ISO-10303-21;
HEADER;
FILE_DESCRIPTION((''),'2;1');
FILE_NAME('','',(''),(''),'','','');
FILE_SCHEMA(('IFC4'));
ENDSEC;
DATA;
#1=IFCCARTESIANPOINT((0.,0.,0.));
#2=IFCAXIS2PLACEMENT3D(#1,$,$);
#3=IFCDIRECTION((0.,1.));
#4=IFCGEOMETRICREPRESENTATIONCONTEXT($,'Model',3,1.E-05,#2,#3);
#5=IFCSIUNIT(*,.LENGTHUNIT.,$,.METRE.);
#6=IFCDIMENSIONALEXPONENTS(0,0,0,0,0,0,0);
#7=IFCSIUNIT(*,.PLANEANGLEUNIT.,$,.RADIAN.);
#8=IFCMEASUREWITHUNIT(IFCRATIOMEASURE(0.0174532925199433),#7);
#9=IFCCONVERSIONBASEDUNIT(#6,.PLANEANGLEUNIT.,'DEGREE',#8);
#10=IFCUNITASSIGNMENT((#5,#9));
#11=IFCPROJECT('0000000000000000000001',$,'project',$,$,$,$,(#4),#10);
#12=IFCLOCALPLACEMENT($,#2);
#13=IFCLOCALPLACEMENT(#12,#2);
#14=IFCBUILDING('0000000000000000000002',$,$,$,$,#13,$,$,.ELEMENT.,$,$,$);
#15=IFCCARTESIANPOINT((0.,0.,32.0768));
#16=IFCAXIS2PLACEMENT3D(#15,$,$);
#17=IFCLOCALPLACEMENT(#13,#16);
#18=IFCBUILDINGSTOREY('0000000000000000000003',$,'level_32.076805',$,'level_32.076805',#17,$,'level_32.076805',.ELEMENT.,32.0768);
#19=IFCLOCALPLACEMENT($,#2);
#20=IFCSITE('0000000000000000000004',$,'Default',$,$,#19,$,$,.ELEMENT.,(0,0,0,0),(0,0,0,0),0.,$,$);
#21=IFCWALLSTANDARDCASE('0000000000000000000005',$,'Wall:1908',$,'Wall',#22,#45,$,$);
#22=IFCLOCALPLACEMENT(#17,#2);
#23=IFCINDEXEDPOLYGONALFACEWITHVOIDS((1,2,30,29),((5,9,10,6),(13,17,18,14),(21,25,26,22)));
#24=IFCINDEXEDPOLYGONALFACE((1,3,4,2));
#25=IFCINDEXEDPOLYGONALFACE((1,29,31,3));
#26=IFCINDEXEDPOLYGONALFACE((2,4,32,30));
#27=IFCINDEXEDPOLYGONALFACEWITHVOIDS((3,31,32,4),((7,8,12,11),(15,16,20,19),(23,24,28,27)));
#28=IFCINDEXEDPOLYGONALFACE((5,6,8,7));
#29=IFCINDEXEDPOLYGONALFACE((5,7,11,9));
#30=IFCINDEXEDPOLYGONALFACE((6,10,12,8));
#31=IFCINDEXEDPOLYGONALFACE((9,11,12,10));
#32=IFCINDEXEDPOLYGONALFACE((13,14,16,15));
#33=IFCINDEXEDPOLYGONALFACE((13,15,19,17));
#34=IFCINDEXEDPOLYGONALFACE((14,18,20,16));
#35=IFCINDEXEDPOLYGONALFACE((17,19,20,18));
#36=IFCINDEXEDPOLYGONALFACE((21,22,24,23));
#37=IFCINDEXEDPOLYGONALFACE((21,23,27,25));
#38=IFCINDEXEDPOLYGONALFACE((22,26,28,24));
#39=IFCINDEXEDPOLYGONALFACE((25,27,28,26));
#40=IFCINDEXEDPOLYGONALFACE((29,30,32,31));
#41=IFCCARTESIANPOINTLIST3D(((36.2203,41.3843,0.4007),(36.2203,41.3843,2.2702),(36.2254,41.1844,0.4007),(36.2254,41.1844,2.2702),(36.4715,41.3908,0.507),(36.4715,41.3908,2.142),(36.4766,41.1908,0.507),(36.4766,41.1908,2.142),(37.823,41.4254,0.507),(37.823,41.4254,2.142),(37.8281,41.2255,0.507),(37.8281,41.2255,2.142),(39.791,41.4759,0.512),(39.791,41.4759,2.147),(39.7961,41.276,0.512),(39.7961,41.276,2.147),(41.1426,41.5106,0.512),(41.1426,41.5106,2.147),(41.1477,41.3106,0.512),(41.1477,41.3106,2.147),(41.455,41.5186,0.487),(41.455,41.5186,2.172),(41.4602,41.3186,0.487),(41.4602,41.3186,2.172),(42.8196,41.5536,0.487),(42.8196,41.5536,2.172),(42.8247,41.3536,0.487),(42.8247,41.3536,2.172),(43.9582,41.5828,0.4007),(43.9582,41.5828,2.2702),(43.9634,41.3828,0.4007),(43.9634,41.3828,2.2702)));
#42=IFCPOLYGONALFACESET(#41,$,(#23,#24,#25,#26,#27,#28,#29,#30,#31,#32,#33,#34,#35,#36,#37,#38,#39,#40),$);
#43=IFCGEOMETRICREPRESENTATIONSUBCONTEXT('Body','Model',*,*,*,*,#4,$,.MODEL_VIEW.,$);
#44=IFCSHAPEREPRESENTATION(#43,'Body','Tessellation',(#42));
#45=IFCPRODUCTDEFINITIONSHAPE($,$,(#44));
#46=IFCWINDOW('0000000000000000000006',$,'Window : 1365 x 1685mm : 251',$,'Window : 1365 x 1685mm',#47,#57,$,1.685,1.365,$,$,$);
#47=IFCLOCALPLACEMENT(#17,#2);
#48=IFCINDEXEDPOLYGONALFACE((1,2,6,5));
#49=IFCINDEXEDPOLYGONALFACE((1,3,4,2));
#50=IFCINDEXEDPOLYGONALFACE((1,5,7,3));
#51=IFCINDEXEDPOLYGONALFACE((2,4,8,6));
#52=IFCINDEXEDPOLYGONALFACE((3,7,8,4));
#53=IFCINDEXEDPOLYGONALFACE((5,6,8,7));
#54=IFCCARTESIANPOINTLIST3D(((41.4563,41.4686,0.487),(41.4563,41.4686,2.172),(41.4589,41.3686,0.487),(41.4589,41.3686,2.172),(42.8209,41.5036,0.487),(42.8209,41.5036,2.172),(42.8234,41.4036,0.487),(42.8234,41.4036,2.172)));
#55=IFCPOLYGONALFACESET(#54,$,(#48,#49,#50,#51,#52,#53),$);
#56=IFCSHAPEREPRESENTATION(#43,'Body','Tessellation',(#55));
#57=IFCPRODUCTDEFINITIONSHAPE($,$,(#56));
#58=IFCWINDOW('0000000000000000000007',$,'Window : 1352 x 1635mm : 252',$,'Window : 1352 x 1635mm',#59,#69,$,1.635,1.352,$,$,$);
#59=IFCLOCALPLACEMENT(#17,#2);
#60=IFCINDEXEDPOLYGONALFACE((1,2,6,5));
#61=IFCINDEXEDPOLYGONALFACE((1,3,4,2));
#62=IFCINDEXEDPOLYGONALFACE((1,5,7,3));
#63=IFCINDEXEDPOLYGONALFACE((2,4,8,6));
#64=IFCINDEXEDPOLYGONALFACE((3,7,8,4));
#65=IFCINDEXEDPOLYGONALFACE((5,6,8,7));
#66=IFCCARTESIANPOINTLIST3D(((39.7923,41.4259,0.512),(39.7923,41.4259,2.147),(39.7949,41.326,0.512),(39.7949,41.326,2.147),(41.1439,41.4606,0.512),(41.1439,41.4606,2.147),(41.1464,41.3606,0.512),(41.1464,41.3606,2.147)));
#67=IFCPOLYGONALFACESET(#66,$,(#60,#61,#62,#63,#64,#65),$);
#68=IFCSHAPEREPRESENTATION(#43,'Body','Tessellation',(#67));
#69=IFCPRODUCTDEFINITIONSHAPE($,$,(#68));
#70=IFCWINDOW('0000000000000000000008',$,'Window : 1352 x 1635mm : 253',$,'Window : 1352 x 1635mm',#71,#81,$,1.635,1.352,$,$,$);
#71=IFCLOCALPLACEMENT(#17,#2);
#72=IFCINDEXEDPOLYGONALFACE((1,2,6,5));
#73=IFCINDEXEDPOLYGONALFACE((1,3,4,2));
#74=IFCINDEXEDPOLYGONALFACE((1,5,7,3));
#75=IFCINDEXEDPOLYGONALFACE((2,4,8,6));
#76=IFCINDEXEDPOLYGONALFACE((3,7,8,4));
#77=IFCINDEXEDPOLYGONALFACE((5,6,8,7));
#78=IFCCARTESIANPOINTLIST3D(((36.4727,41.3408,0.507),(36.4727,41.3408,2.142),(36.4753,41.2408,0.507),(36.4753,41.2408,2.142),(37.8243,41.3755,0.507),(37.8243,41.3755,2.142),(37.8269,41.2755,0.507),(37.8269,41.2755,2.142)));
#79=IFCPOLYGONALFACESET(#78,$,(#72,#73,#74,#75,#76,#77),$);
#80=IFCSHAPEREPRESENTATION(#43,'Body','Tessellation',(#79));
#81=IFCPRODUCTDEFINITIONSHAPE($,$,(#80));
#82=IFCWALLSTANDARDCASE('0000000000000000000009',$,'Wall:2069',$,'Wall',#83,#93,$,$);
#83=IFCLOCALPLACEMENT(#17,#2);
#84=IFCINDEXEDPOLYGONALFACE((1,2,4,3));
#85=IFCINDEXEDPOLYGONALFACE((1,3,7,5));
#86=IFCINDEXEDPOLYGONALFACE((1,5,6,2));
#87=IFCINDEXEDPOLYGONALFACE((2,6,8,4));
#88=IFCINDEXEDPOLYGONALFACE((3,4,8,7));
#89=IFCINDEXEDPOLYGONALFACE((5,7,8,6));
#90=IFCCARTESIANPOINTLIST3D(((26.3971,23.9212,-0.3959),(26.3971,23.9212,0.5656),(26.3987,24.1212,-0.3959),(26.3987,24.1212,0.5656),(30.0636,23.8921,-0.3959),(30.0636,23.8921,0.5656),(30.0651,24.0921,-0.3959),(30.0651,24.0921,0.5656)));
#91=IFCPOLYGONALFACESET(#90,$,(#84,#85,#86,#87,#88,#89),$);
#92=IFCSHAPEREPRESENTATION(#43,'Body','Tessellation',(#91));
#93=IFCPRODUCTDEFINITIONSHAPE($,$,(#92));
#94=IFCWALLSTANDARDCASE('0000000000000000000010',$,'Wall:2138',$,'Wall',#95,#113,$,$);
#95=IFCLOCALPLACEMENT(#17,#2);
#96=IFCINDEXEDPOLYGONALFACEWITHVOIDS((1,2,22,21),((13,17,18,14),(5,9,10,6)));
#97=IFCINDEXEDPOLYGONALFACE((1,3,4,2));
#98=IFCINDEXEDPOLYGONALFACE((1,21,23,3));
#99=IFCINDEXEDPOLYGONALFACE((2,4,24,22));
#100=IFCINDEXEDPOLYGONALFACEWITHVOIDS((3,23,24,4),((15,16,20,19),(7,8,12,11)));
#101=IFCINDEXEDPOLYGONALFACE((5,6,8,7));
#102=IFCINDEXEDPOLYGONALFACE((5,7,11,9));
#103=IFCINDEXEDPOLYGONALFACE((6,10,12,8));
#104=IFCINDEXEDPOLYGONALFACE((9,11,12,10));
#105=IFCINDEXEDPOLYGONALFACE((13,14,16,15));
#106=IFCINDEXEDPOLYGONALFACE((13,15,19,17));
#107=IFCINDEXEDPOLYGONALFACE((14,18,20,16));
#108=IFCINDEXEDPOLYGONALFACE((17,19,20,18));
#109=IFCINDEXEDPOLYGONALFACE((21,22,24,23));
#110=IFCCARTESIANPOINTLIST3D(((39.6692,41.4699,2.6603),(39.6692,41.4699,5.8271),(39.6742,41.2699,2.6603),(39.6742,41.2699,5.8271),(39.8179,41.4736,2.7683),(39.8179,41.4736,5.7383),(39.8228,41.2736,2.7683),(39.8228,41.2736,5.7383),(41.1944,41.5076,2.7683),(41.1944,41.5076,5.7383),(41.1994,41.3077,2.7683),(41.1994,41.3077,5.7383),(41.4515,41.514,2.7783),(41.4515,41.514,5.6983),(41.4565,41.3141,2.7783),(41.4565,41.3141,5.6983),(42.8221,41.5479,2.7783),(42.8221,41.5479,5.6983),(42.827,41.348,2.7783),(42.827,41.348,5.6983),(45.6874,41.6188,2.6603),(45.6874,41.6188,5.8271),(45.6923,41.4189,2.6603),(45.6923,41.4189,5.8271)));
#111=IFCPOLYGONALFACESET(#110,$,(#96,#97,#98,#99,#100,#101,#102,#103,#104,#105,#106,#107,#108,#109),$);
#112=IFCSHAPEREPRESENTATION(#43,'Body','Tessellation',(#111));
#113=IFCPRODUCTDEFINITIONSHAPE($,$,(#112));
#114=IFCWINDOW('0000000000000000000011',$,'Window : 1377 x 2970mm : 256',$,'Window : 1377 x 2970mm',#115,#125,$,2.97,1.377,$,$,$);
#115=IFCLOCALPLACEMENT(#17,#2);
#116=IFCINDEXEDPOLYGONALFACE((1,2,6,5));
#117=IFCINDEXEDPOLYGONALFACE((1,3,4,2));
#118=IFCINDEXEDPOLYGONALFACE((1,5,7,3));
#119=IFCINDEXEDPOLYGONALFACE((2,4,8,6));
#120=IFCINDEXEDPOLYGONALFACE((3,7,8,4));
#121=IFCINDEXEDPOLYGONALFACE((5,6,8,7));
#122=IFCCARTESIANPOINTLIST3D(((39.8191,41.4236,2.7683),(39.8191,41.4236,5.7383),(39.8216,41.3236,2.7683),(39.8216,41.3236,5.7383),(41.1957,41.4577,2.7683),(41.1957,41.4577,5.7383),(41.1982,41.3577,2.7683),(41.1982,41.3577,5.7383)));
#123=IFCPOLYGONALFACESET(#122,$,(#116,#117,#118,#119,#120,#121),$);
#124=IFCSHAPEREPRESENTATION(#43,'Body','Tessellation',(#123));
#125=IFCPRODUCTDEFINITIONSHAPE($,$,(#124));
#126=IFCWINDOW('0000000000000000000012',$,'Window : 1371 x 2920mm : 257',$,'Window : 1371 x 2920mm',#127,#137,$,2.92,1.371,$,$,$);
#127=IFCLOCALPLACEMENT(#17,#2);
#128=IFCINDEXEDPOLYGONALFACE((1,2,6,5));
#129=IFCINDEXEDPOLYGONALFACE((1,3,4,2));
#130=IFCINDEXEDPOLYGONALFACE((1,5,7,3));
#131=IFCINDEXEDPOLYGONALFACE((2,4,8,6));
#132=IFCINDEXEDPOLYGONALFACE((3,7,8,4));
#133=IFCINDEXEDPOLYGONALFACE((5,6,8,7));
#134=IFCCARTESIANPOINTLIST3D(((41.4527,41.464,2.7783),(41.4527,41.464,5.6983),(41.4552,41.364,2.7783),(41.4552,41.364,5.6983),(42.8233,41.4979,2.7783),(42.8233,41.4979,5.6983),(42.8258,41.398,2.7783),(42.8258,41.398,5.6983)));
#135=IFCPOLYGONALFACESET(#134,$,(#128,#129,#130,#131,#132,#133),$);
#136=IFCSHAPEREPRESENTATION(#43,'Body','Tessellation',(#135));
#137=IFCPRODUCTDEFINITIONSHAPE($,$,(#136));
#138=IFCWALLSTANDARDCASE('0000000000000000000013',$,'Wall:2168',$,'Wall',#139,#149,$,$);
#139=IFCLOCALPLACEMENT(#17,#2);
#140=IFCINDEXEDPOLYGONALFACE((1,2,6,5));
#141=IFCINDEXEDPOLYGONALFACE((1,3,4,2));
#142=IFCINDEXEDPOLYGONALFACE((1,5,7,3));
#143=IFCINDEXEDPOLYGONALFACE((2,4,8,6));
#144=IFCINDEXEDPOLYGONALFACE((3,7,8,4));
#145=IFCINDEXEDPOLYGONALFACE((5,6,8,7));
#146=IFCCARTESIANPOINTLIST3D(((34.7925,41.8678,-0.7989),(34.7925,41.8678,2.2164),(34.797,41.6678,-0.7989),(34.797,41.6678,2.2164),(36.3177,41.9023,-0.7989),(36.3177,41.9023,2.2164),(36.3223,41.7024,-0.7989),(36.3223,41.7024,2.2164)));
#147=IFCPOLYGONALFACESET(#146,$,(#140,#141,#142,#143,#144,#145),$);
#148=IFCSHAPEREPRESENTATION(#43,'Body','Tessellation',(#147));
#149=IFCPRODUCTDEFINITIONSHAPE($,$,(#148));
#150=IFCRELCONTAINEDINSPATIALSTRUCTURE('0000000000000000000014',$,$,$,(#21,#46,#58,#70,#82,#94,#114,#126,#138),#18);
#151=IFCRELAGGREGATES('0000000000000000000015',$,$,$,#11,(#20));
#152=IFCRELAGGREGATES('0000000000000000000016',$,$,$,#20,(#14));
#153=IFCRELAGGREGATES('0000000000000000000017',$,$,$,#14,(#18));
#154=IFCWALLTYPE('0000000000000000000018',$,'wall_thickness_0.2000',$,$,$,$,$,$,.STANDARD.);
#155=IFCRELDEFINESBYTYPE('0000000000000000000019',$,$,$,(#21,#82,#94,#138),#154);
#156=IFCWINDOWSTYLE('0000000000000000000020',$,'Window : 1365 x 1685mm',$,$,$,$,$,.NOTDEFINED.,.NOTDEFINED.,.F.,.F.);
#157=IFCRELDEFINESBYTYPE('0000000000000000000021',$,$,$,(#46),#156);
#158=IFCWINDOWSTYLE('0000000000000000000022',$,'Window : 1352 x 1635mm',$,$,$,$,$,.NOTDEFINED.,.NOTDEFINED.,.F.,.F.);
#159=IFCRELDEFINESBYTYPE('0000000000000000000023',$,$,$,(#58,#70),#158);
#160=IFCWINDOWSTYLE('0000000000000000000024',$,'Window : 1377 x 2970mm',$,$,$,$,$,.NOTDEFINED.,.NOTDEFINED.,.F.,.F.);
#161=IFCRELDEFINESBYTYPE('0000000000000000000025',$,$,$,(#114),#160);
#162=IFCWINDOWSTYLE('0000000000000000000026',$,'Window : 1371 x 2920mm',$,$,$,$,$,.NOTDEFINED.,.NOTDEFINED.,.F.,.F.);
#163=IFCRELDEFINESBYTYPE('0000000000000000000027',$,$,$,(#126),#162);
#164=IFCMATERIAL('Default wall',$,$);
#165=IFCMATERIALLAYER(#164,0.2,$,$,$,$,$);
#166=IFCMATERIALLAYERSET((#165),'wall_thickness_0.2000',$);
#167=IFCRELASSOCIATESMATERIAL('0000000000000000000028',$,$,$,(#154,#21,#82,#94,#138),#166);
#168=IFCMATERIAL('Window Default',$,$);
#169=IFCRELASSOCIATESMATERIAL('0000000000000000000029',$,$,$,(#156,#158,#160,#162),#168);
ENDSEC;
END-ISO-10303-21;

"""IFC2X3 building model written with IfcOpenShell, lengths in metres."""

from ifc_helpers import new_model, entity, si_unit, converted_unit, direction, frame, frame_2d, origin, origin_2d_with_axis, place, context, subcontext, project, spatial, polyline, rectangle, outline, extrude, source, transform, mapped, material, layer, layer_set, layer_usage, type_object, type_shapes, element, fill, save


model = new_model("IFC2X3")

# Units and contexts
model_context = context("Model", 3, precision=1e-05, world=origin(), true_north=direction((0.0, 1.0)))
body_context = subcontext(model_context, "Body", "Model", "MODEL_VIEW")
ifc_project = project(units=[si_unit("LENGTHUNIT", "METRE"), converted_unit("PLANEANGLEUNIT", "DEGREE", entity("IfcRatioMeasure", 0.0174532925199433), si_unit("PLANEANGLEUNIT", "RADIAN"), dimensions=[0, 0, 0, 0, 0, 0, 0])], contexts=[model_context])

# Site, building, storey
site_placement = place(None, origin())
site = spatial("IfcSite", under=ifc_project, at=site_placement, Name="Default", CompositionType="ELEMENT", RefLatitude=(0, 0, 0, 0), RefLongitude=(0, 0, 0, 0), RefElevation=0.0)
placement_1 = place(None, origin())
building_placement = place(placement_1, origin())
building = spatial("IfcBuilding", under=site, at=building_placement, CompositionType="ELEMENT")
storey_placement = place(building_placement, frame((0.0, 0.0, 32.0768)))
storey = spatial("IfcBuildingStorey", under=building, at=storey_placement, Name="level_32.076805", ObjectType="level_32.076805", LongName="level_32.076805", CompositionType="ELEMENT", Elevation=32.0768)

# Shared definitions
ifc_material_1 = material(Name="Default wall")
ifc_layer = layer(ifc_material_1, 0.2)
ifc_layer_set = layer_set([ifc_layer], Name="wall_thickness_0.2000")
ifc_layer_usage = layer_usage(ifc_layer_set, "AXIS2", "POSITIVE", -0.1)
wall_type = type_object("IfcWallType", Name="wall_thickness_0.2000", PredefinedType="STANDARD", material=ifc_layer_set)

# Wall, openings, windows
placement_2 = place(building_placement, frame((0.0, 0.0, 32.4775)))
wall_1_placement = place(placement_2, frame((36.2228, 41.2844, 0.0), z_axis=(0.0, 0.0, 1.0), x_axis=(0.999671, 0.025636, 0.0)))
wall_1 = element("IfcWallStandardCase", 1, at=wall_1_placement, inside=storey, type_object=wall_type, material=ifc_layer_usage, Name="Wall:1908", ObjectType="Wall", context=body_context, shape_type="SweptSolid", body=[
    extrude(outline(polyline([(7.7405, -0.1), (7.7405, 0.1), (0.0, 0.1), (0.0, -0.1), (7.7405, -0.1)])), origin(), (0.0, 0.0, 1.0), 1.8695),
])
opening_1_placement = place(wall_1_placement, frame((5.2365, -0.1, 0.0863)))
opening_1 = element("IfcOpeningElement", 2, at=opening_1_placement, cuts=wall_1, ObjectType="Opening", context=body_context, shape_type="SweptSolid", body=[
    extrude(rectangle(XDim=1.365, YDim=1.685, at=frame_2d((0.8425, 0.6825), x_axis=(0.0, 1.0))), frame((0.0, 0.0, 0.0), z_axis=(0.0, 1.0, 0.0), x_axis=(0.0, 0.0, 1.0)), (0.0, 0.0, 1.0), 0.2),
])
opening_2_placement = place(wall_1_placement, frame((3.5719, -0.1, 0.1113)))
opening_2 = element("IfcOpeningElement", 3, at=opening_2_placement, cuts=wall_1, ObjectType="Opening", context=body_context, shape_type="SweptSolid", body=[
    extrude(rectangle(XDim=1.352, YDim=1.635, at=frame_2d((0.8175, 0.676), x_axis=(0.0, 1.0))), frame((0.0, 0.0, 0.0), z_axis=(0.0, 1.0, 0.0), x_axis=(0.0, 0.0, 1.0)), (0.0, 0.0, 1.0), 0.2),
])
opening_3_placement = place(wall_1_placement, frame((0.2513, -0.1, 0.1063)))
opening_3 = element("IfcOpeningElement", 4, at=opening_3_placement, cuts=wall_1, ObjectType="Opening", context=body_context, shape_type="SweptSolid", body=[
    extrude(rectangle(XDim=1.352, YDim=1.635, at=frame_2d((0.8175, 0.676), x_axis=(0.0, 1.0))), frame((0.0, 0.0, 0.0), z_axis=(0.0, 1.0, 0.0), x_axis=(0.0, 0.0, 1.0)), (0.0, 0.0, 1.0), 0.2),
])
ifc_material_2 = material(Name="Window Default")
window_style_1 = type_object("IfcWindowStyle", Name="Window : 1365 x 1685mm", ConstructionType="NOTDEFINED", OperationType="NOTDEFINED", ParameterTakesPrecedence=False, Sizeable=False, material=ifc_material_2)
shared_shape_1 = source(origin(), body_context, "Body", "SweptSolid", [
    extrude(rectangle(XDim=0.1, YDim=1.365, at=origin_2d_with_axis()), frame((0.6825, 0.1, 0.0), z_axis=(0.0, 0.0, 1.0), x_axis=(0.0, 1.0, 0.0)), (0.0, 0.0, 1.0), 1.685),
])
type_shapes(window_style_1, [shared_shape_1])
window_1_placement = place(opening_1_placement, origin())
window_1 = element("IfcWindow", 5, at=window_1_placement, inside=storey, type_object=window_style_1, Name="Window : 1365 x 1685mm : 251", ObjectType="Window : 1365 x 1685mm", OverallHeight=1.685, OverallWidth=1.365, context=body_context, shape_type="MappedRepresentation", body=[
    mapped(shared_shape_1, transform((0.0, 0.0, 0.0), scale=1.0)),
])
fill(opening_1, window_1)
window_style_2 = type_object("IfcWindowStyle", Name="Window : 1352 x 1635mm", ConstructionType="NOTDEFINED", OperationType="NOTDEFINED", ParameterTakesPrecedence=False, Sizeable=False, material=ifc_material_2)
shared_shape_2 = source(origin(), body_context, "Body", "SweptSolid", [
    extrude(rectangle(XDim=0.1, YDim=1.352, at=origin_2d_with_axis()), frame((0.676, 0.1, 0.0), z_axis=(0.0, 0.0, 1.0), x_axis=(0.0, 1.0, 0.0)), (0.0, 0.0, 1.0), 1.635),
])
type_shapes(window_style_2, [shared_shape_2])
window_2_placement = place(opening_2_placement, origin())
window_2 = element("IfcWindow", 6, at=window_2_placement, inside=storey, type_object=window_style_2, Name="Window : 1352 x 1635mm : 252", ObjectType="Window : 1352 x 1635mm", OverallHeight=1.635, OverallWidth=1.352, context=body_context, shape_type="MappedRepresentation", body=[
    mapped(shared_shape_2, transform((0.0, 0.0, 0.0), scale=1.0)),
])
fill(opening_2, window_2)
window_3_placement = place(opening_3_placement, origin())
window_3 = element("IfcWindow", 7, at=window_3_placement, inside=storey, type_object=window_style_2, Name="Window : 1352 x 1635mm : 253", ObjectType="Window : 1352 x 1635mm", OverallHeight=1.635, OverallWidth=1.352, context=body_context, shape_type="MappedRepresentation", body=[
    mapped(shared_shape_2, transform((0.0, 0.0, 0.0), scale=1.0)),
])
fill(opening_3, window_3)

# Wall
placement_3 = place(building_placement, frame((0.0, 0.0, 31.6809)))
wall_2_placement = place(placement_3, frame((26.3979, 24.0212, 0.0), z_axis=(0.0, 0.0, 1.0), x_axis=(0.999969, -0.007935, 0.0)))
element("IfcWallStandardCase", 8, at=wall_2_placement, inside=storey, type_object=wall_type, material=ifc_layer_usage, Name="Wall:2069", ObjectType="Wall", context=body_context, shape_type="SweptSolid", body=[
    extrude(outline(polyline([(3.6666, -0.1), (3.6666, 0.1), (0.0, 0.1), (0.0, -0.1), (3.6666, -0.1)])), origin(), (0.0, 0.0, 1.0), 0.9616),
])

# Wall, openings, windows
placement_4 = place(building_placement, frame((0.0, 0.0, 34.7371)))
wall_3_placement = place(placement_4, frame((39.6717, 41.3699, 0.0), z_axis=(0.0, 0.0, 1.0), x_axis=(0.999694, 0.024744, 0.0)))
wall_3 = element("IfcWallStandardCase", 9, at=wall_3_placement, inside=storey, type_object=wall_type, material=ifc_layer_usage, Name="Wall:2138", ObjectType="Wall", context=body_context, shape_type="SweptSolid", body=[
    extrude(outline(polyline([(6.02, -0.1), (6.02, 0.1), (0.0, 0.1), (0.0, -0.1), (6.02, -0.1)])), origin(), (0.0, 0.0, 1.0), 3.1668),
])
opening_4_placement = place(wall_3_placement, frame((0.1487, -0.1, 0.108)))
opening_4 = element("IfcOpeningElement", 10, at=opening_4_placement, cuts=wall_3, ObjectType="Opening", context=body_context, shape_type="SweptSolid", body=[
    extrude(rectangle(XDim=1.377, YDim=2.97, at=frame_2d((1.485, 0.6885), x_axis=(0.0, 1.0))), frame((0.0, 0.0, 0.0), z_axis=(0.0, 1.0, 0.0), x_axis=(0.0, 0.0, 1.0)), (0.0, 0.0, 1.0), 0.2),
])
opening_5_placement = place(wall_3_placement, frame((1.7828, -0.1, 0.118)))
opening_5 = element("IfcOpeningElement", 11, at=opening_5_placement, cuts=wall_3, ObjectType="Opening", context=body_context, shape_type="SweptSolid", body=[
    extrude(rectangle(XDim=1.371, YDim=2.92, at=frame_2d((1.46, 0.6855), x_axis=(0.0, 1.0))), frame((0.0, 0.0, 0.0), z_axis=(0.0, 1.0, 0.0), x_axis=(0.0, 0.0, 1.0)), (0.0, 0.0, 1.0), 0.2),
])
window_style_3 = type_object("IfcWindowStyle", Name="Window : 1377 x 2970mm", ConstructionType="NOTDEFINED", OperationType="NOTDEFINED", ParameterTakesPrecedence=False, Sizeable=False, material=ifc_material_2)
shared_shape_3 = source(origin(), body_context, "Body", "SweptSolid", [
    extrude(rectangle(XDim=0.1, YDim=1.377, at=origin_2d_with_axis()), frame((0.6885, 0.1, 0.0), z_axis=(0.0, 0.0, 1.0), x_axis=(0.0, 1.0, 0.0)), (0.0, 0.0, 1.0), 2.97),
])
type_shapes(window_style_3, [shared_shape_3])
window_4_placement = place(opening_4_placement, origin())
window_4 = element("IfcWindow", 12, at=window_4_placement, inside=storey, type_object=window_style_3, Name="Window : 1377 x 2970mm : 256", ObjectType="Window : 1377 x 2970mm", OverallHeight=2.97, OverallWidth=1.377, context=body_context, shape_type="MappedRepresentation", body=[
    mapped(shared_shape_3, transform((0.0, 0.0, 0.0), scale=1.0)),
])
fill(opening_4, window_4)
window_style_4 = type_object("IfcWindowStyle", Name="Window : 1371 x 2920mm", ConstructionType="NOTDEFINED", OperationType="NOTDEFINED", ParameterTakesPrecedence=False, Sizeable=False, material=ifc_material_2)
shared_shape_4 = source(origin(), body_context, "Body", "SweptSolid", [
    extrude(rectangle(XDim=0.1, YDim=1.371, at=origin_2d_with_axis()), frame((0.6855, 0.1, 0.0), z_axis=(0.0, 0.0, 1.0), x_axis=(0.0, 1.0, 0.0)), (0.0, 0.0, 1.0), 2.92),
])
type_shapes(window_style_4, [shared_shape_4])
window_5_placement = place(opening_5_placement, origin())
window_5 = element("IfcWindow", 13, at=window_5_placement, inside=storey, type_object=window_style_4, Name="Window : 1371 x 2920mm : 257", ObjectType="Window : 1371 x 2920mm", OverallHeight=2.92, OverallWidth=1.371, context=body_context, shape_type="MappedRepresentation", body=[
    mapped(shared_shape_4, transform((0.0, 0.0, 0.0), scale=1.0)),
])
fill(opening_5, window_5)

# Wall
placement_5 = place(building_placement, frame((0.0, 0.0, 31.2779)))
wall_4_placement = place(placement_5, frame((36.32, 41.8023, 0.0), z_axis=(0.0, 0.0, 1.0), x_axis=(-0.999744, -0.022616, 0.0)))
element("IfcWallStandardCase", 14, at=wall_4_placement, inside=storey, type_object=wall_type, material=ifc_layer_usage, Name="Wall:2168", ObjectType="Wall", context=body_context, shape_type="SweptSolid", body=[
    extrude(outline(polyline([(1.5256, -0.1), (1.5256, 0.1), (0.0, 0.1), (0.0, -0.1), (1.5256, -0.1)])), origin(), (0.0, 0.0, 1.0), 3.0152),
])

save(model, "model.ifc")
